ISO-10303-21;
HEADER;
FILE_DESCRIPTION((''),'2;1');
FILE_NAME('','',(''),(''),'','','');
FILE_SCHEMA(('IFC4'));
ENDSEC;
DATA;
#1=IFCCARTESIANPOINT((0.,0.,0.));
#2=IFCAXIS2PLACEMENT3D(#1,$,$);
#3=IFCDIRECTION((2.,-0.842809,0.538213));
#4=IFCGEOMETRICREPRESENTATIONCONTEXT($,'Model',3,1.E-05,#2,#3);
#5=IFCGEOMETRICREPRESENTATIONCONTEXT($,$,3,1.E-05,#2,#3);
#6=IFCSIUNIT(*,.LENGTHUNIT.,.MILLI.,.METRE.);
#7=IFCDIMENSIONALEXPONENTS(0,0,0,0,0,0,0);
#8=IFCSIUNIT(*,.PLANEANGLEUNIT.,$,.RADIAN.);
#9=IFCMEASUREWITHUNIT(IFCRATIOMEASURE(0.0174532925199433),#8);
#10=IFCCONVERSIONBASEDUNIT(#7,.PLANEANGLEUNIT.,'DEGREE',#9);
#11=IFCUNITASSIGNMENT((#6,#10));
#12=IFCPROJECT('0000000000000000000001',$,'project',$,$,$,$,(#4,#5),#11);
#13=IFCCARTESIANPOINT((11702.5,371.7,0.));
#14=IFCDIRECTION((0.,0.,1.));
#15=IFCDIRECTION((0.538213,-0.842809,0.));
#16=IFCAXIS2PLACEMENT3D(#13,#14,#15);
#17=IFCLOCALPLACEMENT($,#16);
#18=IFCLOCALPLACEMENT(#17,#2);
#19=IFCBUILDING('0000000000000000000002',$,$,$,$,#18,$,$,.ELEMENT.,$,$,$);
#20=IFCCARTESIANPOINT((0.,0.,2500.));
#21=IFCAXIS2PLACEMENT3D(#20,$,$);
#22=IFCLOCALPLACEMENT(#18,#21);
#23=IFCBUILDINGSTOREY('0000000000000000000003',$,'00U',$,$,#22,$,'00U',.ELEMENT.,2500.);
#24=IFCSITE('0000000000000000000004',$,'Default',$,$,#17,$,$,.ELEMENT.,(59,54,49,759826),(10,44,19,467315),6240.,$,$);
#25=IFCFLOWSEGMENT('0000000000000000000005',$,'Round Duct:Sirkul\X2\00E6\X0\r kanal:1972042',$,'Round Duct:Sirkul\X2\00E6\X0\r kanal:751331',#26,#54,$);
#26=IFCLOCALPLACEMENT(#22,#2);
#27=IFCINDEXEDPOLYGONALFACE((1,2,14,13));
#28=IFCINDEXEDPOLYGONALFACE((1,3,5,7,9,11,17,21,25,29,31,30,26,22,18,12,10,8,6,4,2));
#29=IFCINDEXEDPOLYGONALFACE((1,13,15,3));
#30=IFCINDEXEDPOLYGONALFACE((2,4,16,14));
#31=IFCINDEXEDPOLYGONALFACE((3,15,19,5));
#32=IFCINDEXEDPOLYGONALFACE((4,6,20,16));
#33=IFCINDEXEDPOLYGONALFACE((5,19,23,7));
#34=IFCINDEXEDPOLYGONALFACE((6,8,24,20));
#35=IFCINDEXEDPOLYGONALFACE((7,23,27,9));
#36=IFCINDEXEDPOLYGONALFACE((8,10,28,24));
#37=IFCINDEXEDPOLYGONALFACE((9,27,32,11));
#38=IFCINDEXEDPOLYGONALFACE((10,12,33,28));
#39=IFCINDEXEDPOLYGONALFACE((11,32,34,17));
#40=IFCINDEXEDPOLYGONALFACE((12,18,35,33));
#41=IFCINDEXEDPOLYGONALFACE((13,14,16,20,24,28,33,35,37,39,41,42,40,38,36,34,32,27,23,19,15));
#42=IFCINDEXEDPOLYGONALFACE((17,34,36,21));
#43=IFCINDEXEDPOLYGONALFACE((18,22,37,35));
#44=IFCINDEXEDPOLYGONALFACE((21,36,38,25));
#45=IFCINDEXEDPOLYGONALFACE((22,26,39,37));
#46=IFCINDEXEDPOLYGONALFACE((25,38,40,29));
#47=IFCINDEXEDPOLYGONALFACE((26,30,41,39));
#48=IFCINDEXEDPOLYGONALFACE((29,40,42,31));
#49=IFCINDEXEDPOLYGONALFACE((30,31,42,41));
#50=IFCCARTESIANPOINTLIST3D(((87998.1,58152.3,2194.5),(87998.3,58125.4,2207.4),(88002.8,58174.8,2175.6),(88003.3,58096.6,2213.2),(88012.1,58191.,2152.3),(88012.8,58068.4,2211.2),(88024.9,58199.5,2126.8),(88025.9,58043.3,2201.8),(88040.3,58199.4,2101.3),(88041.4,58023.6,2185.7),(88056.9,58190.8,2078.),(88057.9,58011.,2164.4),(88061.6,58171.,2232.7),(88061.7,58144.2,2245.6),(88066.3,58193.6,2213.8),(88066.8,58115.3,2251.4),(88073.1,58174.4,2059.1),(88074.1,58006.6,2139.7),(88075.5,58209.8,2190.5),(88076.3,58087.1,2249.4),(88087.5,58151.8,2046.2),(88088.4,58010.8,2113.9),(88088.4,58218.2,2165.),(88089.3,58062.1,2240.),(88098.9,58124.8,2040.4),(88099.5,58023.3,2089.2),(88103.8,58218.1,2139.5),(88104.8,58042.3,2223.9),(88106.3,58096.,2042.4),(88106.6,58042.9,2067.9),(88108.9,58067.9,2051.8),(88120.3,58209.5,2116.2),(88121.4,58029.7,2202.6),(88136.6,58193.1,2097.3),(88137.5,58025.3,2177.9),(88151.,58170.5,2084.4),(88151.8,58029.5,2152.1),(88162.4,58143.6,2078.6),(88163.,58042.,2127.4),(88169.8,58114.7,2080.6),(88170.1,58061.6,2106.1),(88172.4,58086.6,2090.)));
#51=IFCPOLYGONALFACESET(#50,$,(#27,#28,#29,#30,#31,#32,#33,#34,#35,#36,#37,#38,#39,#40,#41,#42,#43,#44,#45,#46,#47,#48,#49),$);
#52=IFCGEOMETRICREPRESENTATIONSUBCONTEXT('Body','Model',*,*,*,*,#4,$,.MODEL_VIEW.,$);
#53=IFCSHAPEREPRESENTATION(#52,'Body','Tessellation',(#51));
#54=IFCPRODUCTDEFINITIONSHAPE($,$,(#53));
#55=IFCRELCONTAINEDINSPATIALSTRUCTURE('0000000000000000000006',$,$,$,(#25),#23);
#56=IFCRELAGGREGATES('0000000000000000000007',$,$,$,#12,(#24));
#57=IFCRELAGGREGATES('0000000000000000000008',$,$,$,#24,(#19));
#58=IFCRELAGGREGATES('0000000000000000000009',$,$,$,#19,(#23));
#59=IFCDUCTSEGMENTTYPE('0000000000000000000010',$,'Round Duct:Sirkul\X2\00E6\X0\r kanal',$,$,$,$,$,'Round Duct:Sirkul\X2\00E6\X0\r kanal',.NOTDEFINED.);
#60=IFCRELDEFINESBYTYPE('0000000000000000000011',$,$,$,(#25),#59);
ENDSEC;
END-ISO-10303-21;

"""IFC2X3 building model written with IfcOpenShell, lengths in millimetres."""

from ifc_helpers import new_model, entity, si_unit, converted_unit, direction, frame, frame_2d, origin, place, context, subcontext, project, spatial, circle, extrude, type_object, element, save


model = new_model("IFC2X3")

# Units and contexts
model_context = context("Model", 3, precision=1e-05, world=origin(), true_north=direction((2.0, -0.842809, 0.538213)))
context_of_model = context(None, 3, precision=1e-05, world=origin(), true_north=direction((2.0, -0.842809, 0.538213)))
body_context = subcontext(model_context, "Body", "Model", "MODEL_VIEW")
ifc_project = project(units=[si_unit("LENGTHUNIT", "METRE", prefix="MILLI"), converted_unit("PLANEANGLEUNIT", "DEGREE", entity("IfcRatioMeasure", 0.0174532925199433), si_unit("PLANEANGLEUNIT", "RADIAN"), dimensions=[0, 0, 0, 0, 0, 0, 0])], contexts=[model_context, context_of_model])

# Site, building, storey
site_placement = place(None, frame((11702.5, 371.7, 0.0), z_axis=(0.0, 0.0, 1.0), x_axis=(0.538213, -0.842809, 0.0)))
site = spatial("IfcSite", under=ifc_project, at=site_placement, Name="Default", CompositionType="ELEMENT", RefLatitude=(59, 54, 49, 759826), RefLongitude=(10, 44, 19, 467315), RefElevation=6240.0)
building_placement = place(site_placement, origin())
building = spatial("IfcBuilding", under=site, at=building_placement, CompositionType="ELEMENT")
storey_placement = place(building_placement, frame((0.0, 0.0, 2500.0)))
storey = spatial("IfcBuildingStorey", under=building, at=storey_placement, Name="00U", LongName="00U", CompositionType="ELEMENT", Elevation=2500.0)

# Flow segment
duct_segment_type_1 = type_object("IfcDuctSegmentType", Name="Round Duct:Sirkulær kanal", ElementType="Round Duct:Sirkulær kanal", PredefinedType="NOTDEFINED")
flow_segment_1_placement = place(storey_placement, origin())
element("IfcFlowSegment", 1, at=flow_segment_1_placement, inside=storey, type_object=duct_segment_type_1, Name="Round Duct:Sirkulær kanal:1972042", ObjectType="Round Duct:Sirkulær kanal:751331", context=body_context, shape_type="SweptSolid", body=[
    extrude(circle(Radius=100.0, at=frame_2d((0.0, 0.0), x_axis=(1.0, 0.0))), frame((88053.2, 58103.6, 2126.8), z_axis=(0.830628, 0.245064, 0.5), x_axis=(-0.282976, 0.959127, 0.0)), (0.0, 0.0, 1.0), 76.4),
])

save(model, "model.ifc")
